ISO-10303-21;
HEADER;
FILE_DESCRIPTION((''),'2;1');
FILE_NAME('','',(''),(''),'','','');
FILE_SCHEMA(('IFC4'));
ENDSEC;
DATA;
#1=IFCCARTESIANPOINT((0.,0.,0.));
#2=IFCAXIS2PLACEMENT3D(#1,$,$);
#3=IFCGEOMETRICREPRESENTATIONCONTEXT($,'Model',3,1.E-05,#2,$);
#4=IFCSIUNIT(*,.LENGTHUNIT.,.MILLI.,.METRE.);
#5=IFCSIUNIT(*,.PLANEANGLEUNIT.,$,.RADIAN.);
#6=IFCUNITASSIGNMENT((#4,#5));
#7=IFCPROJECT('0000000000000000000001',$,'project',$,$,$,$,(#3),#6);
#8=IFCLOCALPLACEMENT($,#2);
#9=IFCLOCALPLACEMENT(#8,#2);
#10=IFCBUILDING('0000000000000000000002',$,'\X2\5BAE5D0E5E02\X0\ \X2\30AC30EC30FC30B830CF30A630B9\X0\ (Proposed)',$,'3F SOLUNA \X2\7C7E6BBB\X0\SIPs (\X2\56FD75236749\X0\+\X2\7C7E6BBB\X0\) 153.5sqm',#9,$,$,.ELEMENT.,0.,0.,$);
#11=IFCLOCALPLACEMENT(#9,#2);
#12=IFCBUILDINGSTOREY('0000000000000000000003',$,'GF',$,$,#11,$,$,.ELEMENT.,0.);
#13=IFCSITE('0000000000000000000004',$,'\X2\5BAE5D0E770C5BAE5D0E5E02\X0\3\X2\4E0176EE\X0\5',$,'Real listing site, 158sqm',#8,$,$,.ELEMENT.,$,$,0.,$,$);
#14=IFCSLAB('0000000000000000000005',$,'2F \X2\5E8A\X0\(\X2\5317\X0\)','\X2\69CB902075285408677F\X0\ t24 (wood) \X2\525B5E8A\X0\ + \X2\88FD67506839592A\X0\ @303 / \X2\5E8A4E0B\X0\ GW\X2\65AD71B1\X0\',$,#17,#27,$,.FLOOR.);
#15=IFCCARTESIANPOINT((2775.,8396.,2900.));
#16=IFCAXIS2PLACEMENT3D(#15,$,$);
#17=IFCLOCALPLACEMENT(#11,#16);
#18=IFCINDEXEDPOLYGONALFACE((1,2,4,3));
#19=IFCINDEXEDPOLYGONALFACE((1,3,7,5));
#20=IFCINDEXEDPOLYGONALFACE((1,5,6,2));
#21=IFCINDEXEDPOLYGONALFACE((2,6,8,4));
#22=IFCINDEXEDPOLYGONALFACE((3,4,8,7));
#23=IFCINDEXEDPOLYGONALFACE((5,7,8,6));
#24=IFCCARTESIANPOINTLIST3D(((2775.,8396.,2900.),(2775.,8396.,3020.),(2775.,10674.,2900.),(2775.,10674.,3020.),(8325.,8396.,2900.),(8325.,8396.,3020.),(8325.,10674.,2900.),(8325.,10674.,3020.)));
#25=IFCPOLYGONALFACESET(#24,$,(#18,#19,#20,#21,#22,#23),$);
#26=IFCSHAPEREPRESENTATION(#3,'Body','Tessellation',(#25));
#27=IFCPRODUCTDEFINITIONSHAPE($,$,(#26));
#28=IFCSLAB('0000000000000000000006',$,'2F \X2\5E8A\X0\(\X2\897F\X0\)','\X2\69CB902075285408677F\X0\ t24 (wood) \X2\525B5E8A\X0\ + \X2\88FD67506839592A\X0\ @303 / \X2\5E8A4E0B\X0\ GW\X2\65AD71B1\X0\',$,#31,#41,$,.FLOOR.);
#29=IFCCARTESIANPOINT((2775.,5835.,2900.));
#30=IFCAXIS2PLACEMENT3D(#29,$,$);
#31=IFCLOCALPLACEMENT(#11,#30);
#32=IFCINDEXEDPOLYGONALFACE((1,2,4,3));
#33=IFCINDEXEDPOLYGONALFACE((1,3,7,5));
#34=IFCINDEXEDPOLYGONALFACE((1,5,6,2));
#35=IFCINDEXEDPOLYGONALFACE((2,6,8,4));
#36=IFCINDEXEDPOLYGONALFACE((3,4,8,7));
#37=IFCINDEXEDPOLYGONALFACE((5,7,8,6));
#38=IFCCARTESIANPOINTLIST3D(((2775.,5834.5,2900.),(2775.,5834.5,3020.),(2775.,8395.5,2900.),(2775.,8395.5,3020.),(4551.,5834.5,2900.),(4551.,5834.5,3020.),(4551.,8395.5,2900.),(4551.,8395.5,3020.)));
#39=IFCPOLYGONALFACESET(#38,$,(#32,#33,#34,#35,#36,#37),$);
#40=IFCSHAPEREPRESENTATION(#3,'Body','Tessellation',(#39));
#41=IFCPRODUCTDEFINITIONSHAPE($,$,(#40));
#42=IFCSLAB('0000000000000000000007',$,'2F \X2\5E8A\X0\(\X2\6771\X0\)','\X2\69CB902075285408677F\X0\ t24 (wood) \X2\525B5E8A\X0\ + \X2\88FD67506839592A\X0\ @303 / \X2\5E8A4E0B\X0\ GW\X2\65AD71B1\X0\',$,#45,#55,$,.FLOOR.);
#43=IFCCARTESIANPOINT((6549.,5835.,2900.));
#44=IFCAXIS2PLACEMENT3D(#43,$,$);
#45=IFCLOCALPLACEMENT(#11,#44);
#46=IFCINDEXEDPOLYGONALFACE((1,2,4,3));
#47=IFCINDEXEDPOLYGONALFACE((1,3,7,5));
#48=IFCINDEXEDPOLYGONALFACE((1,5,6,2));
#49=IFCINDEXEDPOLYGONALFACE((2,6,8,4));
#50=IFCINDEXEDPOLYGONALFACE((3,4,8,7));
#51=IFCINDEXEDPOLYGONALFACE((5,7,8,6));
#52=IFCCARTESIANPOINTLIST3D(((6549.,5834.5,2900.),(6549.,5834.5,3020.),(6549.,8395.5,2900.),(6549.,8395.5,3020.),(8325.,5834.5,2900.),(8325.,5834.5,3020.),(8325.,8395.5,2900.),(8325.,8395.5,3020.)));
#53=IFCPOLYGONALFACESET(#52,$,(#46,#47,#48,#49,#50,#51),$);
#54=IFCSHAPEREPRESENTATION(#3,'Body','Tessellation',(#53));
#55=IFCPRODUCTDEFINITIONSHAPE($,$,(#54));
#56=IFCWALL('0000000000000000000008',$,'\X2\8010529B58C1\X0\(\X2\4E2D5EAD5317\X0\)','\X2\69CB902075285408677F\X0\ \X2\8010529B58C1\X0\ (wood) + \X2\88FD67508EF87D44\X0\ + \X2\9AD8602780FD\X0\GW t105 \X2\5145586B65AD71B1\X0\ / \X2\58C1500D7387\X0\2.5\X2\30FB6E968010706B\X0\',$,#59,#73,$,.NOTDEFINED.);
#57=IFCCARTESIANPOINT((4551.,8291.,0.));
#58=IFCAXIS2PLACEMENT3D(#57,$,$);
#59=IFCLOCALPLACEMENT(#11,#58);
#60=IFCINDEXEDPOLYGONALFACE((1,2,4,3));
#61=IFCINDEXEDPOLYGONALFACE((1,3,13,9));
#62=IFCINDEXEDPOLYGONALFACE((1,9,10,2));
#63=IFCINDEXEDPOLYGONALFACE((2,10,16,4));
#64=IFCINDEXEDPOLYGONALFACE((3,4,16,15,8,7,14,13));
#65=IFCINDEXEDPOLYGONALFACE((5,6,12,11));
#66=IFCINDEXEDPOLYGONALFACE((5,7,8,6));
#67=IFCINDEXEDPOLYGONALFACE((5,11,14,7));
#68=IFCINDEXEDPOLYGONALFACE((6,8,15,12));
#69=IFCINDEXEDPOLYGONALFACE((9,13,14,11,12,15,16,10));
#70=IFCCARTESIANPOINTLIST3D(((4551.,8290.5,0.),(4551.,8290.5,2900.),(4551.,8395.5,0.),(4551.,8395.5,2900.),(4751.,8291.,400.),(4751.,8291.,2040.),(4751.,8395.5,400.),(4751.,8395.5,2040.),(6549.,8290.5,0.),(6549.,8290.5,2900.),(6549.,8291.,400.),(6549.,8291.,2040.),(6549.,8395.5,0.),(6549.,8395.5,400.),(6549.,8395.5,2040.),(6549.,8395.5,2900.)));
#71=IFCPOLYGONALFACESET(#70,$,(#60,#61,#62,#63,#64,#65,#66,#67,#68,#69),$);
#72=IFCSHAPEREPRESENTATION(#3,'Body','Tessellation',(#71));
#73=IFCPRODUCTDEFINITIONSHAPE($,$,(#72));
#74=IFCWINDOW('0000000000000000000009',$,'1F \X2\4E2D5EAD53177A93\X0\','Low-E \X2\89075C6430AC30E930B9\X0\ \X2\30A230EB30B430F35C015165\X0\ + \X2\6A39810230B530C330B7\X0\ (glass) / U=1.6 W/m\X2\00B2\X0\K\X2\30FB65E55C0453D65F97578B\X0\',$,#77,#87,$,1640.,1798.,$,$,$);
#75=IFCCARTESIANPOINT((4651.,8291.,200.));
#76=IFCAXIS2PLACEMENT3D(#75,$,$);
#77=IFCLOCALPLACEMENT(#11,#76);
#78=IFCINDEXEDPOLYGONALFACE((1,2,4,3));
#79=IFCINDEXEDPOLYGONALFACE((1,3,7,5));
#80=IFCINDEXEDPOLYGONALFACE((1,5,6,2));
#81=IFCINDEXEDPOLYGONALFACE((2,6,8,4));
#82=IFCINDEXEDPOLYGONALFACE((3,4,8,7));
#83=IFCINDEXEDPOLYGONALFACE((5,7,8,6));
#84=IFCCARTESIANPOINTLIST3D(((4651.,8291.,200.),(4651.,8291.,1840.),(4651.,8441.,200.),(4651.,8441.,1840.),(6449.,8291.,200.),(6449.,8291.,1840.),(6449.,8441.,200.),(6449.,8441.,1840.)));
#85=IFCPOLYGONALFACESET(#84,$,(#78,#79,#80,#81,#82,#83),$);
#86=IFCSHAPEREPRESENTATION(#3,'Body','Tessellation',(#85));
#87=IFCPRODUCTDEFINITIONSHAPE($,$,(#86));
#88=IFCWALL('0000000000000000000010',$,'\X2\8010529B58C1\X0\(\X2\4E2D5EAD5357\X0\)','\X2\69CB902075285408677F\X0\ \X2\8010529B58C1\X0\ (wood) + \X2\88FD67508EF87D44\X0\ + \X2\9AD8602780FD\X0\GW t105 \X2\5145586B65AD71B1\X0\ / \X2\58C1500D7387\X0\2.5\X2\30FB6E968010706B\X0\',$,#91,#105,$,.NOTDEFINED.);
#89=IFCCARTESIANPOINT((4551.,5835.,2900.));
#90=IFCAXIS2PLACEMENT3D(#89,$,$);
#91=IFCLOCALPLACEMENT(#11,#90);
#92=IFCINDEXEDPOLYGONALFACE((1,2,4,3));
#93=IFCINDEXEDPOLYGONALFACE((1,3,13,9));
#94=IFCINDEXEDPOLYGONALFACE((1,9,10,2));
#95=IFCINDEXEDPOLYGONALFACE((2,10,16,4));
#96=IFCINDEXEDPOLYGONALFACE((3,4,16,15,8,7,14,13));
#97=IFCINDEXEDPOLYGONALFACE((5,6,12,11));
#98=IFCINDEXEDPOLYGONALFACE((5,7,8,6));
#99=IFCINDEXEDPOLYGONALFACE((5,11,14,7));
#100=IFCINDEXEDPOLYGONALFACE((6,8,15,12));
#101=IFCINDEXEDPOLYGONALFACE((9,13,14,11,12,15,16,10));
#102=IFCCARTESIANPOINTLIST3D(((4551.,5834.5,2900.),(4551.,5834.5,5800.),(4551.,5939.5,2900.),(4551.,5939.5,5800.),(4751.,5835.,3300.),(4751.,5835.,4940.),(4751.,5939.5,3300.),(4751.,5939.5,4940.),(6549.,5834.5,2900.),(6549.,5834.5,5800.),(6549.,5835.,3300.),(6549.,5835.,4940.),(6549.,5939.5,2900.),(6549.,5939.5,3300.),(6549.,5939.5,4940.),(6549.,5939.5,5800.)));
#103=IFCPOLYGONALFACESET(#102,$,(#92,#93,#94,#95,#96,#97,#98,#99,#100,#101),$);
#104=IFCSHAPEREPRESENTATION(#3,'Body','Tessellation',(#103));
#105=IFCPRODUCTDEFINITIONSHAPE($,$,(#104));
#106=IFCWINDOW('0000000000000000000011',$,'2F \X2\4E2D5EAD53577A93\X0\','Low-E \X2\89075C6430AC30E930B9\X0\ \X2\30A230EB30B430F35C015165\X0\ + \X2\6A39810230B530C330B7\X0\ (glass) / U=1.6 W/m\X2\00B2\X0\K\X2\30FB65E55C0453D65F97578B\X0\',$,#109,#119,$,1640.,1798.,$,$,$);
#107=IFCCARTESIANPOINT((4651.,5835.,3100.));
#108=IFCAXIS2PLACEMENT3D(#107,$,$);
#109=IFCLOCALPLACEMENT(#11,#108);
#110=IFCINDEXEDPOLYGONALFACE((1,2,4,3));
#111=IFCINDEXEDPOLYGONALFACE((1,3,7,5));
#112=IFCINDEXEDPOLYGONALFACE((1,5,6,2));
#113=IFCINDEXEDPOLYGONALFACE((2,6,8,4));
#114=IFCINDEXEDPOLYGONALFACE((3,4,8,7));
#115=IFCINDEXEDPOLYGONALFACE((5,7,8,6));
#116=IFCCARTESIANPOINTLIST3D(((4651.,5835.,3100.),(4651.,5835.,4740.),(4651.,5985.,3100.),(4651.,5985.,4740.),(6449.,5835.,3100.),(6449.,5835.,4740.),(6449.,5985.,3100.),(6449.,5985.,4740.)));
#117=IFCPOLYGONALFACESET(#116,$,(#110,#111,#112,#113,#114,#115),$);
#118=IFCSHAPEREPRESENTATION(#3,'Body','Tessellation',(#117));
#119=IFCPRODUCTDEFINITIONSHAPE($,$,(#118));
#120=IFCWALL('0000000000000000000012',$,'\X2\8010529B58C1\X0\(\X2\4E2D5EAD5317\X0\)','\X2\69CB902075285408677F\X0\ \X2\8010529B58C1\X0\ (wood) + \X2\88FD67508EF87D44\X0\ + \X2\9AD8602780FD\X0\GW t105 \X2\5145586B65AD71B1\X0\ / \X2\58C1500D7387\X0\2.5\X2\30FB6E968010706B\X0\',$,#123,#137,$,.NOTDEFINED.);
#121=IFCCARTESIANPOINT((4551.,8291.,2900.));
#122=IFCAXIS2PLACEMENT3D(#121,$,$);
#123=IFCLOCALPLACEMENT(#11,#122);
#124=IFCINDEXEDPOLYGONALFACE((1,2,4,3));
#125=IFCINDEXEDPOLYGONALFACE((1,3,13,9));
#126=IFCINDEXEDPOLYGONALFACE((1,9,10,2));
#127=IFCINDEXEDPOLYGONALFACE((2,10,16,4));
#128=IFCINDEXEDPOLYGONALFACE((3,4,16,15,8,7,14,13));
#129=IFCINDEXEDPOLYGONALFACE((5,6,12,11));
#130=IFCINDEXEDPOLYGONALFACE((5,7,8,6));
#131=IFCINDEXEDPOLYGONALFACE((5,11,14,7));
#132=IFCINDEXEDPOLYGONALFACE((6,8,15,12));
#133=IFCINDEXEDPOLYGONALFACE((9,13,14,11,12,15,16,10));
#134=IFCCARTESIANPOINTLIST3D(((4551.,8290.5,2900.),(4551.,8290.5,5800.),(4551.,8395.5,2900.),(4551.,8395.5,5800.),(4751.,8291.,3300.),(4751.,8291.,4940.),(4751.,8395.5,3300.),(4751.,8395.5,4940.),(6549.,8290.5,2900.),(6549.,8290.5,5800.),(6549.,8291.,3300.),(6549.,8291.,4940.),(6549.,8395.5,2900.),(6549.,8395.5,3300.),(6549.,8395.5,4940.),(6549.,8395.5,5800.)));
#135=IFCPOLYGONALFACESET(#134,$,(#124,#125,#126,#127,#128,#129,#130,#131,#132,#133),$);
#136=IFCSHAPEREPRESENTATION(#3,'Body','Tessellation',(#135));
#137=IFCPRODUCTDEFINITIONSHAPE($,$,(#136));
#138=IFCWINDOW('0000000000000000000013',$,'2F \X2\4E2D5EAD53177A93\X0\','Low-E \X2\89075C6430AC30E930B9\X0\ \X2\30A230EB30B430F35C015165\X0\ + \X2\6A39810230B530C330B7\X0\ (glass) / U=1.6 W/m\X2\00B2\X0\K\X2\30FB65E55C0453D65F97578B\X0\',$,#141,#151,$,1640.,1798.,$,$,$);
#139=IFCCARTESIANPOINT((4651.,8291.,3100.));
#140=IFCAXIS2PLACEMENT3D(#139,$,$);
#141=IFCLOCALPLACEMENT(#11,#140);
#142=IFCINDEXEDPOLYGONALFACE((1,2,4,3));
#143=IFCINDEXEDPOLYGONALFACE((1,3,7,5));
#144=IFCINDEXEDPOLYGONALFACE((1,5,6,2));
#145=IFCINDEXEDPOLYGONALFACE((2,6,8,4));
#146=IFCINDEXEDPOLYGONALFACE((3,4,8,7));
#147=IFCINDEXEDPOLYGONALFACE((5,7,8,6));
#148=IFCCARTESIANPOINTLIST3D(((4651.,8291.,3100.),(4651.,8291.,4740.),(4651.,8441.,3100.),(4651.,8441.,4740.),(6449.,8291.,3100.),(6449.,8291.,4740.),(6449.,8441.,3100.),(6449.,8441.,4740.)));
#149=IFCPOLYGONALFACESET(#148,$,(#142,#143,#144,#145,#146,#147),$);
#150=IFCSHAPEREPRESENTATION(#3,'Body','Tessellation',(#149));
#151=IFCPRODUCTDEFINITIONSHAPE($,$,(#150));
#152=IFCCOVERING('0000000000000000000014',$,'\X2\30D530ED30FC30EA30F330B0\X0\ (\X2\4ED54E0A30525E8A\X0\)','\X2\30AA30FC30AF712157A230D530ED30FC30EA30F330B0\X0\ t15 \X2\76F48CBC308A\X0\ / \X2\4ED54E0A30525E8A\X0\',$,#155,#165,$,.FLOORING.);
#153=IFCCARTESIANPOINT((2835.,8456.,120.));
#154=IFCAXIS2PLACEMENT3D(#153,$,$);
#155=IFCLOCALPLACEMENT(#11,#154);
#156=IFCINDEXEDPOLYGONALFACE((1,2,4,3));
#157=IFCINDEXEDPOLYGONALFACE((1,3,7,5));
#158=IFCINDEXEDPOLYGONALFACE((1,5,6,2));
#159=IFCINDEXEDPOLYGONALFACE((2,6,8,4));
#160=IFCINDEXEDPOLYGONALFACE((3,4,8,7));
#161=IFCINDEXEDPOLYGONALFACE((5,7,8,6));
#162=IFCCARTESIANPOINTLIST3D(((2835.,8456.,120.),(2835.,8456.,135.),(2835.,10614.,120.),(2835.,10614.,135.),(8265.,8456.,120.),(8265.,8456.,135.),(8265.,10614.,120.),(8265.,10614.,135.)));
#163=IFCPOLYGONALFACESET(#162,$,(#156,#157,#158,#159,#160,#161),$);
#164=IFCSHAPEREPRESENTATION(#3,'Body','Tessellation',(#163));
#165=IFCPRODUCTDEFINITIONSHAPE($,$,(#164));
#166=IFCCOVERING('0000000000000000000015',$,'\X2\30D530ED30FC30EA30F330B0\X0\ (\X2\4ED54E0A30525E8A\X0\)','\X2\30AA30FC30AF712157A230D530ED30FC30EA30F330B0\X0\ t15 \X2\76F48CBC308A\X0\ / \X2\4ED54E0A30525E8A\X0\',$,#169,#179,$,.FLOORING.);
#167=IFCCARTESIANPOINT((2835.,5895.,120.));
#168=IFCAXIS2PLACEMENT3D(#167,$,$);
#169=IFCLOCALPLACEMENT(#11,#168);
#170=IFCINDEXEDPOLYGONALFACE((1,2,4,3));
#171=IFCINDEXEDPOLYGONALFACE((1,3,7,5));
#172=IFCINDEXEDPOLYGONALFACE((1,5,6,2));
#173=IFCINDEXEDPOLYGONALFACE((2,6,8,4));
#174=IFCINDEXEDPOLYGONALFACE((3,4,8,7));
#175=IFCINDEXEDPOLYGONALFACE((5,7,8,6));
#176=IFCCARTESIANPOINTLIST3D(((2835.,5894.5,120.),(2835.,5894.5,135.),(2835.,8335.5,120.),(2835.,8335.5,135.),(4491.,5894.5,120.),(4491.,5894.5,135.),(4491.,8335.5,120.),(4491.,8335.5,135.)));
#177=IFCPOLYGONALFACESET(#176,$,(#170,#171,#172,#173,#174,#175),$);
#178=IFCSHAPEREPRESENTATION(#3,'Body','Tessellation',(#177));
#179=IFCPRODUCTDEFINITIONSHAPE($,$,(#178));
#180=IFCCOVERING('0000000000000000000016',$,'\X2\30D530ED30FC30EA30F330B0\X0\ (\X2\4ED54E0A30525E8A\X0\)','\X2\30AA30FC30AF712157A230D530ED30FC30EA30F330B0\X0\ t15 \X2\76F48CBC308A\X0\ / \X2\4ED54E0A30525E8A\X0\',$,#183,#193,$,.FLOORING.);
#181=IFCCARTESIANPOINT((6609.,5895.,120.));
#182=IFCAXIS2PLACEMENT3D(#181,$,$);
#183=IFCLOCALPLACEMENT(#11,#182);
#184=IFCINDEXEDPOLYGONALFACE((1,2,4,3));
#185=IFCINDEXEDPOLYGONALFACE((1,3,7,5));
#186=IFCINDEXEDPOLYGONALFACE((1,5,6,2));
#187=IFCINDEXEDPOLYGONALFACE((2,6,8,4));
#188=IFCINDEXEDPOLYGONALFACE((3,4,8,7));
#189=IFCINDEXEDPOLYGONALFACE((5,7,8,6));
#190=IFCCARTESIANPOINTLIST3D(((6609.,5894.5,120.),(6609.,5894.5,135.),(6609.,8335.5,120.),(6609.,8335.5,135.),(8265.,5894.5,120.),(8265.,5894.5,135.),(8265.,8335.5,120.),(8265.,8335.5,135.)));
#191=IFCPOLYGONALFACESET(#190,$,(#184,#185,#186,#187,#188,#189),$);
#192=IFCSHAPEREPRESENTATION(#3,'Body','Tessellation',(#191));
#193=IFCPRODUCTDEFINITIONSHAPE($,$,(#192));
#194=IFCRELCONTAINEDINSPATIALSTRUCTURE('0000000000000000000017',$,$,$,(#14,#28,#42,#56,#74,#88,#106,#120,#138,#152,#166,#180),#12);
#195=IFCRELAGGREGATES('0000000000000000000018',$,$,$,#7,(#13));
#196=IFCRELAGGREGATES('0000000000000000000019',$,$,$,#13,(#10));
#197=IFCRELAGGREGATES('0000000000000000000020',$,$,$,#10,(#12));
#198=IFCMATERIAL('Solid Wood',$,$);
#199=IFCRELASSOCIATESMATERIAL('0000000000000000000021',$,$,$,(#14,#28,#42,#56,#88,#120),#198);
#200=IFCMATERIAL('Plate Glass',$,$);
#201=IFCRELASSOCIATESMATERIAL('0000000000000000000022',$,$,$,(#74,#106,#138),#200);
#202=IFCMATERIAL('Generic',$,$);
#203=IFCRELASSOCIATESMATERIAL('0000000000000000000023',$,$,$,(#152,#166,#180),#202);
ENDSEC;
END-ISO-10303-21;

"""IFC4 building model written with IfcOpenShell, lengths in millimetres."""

from ifc_helpers import new_model, si_unit, frame, frame_2d, origin, place, context, project, spatial, rectangle, extrude, material, element, fill, save


model = new_model("IFC4")

# Units and contexts
model_context = context("Model", 3, precision=1e-05, world=origin())
ifc_project = project(units=[si_unit("LENGTHUNIT", "METRE", prefix="MILLI"), si_unit("PLANEANGLEUNIT", "RADIAN")], contexts=[model_context])

# Site, building, storey
site_placement = place(None, origin())
site = spatial("IfcSite", under=ifc_project, at=site_placement, Name="宮崎県宮崎市3丁目5", ObjectType="Real listing site, 158sqm", CompositionType="ELEMENT", RefElevation=0.0)
building_placement = place(site_placement, origin())
building = spatial("IfcBuilding", under=site, at=building_placement, Name="宮崎市 ガレージハウス (Proposed)", ObjectType="3F SOLUNA 籾殻SIPs (国産杉+籾殻) 153.5sqm", CompositionType="ELEMENT", ElevationOfRefHeight=0.0, ElevationOfTerrain=0.0)
storey_placement = place(building_placement, origin())
storey = spatial("IfcBuildingStorey", under=building, at=storey_placement, Name="GF", CompositionType="ELEMENT", Elevation=0.0)

# Slabs
ifc_material_1 = material(Name="Solid Wood")
slab_1_placement = place(storey_placement, frame((2775.0, 8396.0, 2900.0)))
element("IfcSlab", 1, at=slab_1_placement, inside=storey, material=ifc_material_1, Name="2F 床(北)", Description="構造用合板 t24 (wood) 剛床 + 製材根太 @303 / 床下 GW断熱", PredefinedType="FLOOR", context=model_context, shape_type="SweptSolid", body=[
    extrude(rectangle(XDim=5550.0, YDim=2278.0, at=frame_2d((2775.0, 1139.0))), frame((2775.0, 8396.0, 2900.0)), (0.0, 0.0, 1.0), 120.0),
])
slab_2_placement = place(storey_placement, frame((2775.0, 5835.0, 2900.0)))
element("IfcSlab", 2, at=slab_2_placement, inside=storey, material=ifc_material_1, Name="2F 床(西)", Description="構造用合板 t24 (wood) 剛床 + 製材根太 @303 / 床下 GW断熱", PredefinedType="FLOOR", context=model_context, shape_type="SweptSolid", body=[
    extrude(rectangle(XDim=1776.0, YDim=2561.0, at=frame_2d((888.0, 1280.0))), frame((2775.0, 5835.0, 2900.0)), (0.0, 0.0, 1.0), 120.0),
])
slab_3_placement = place(storey_placement, frame((6549.0, 5835.0, 2900.0)))
element("IfcSlab", 3, at=slab_3_placement, inside=storey, material=ifc_material_1, Name="2F 床(東)", Description="構造用合板 t24 (wood) 剛床 + 製材根太 @303 / 床下 GW断熱", PredefinedType="FLOOR", context=model_context, shape_type="SweptSolid", body=[
    extrude(rectangle(XDim=1776.0, YDim=2561.0, at=frame_2d((888.0, 1280.0))), frame((6549.0, 5835.0, 2900.0)), (0.0, 0.0, 1.0), 120.0),
])

# Wall, opening, window
wall_1_placement = place(storey_placement, frame((4551.0, 8291.0, 0.0)))
wall_1 = element("IfcWall", 4, at=wall_1_placement, inside=storey, material=ifc_material_1, Name="耐力壁(中庭北)", Description="構造用合板 耐力壁 (wood) + 製材軸組 + 高性能GW t105 充填断熱 / 壁倍率2.5・準耐火", PredefinedType="NOTDEFINED", context=model_context, shape_type="SweptSolid", body=[
    extrude(rectangle(XDim=1998.0, YDim=105.0, at=frame_2d((999.0, 52.0))), frame((4551.0, 8291.0, 0.0)), (0.0, 0.0, 1.0), 2900.0),
])
opening_1_placement = place(storey_placement, frame((4651.0, 8291.0, 200.0)))
opening_1 = element("IfcOpeningElement", 5, at=opening_1_placement, cuts=wall_1, PredefinedType="NOTDEFINED", context=model_context, shape_type="SweptSolid", body=[
    extrude(rectangle(XDim=1798.0, YDim=150.0, at=frame_2d((899.0, 75.0))), frame((4651.0, 8291.0, 200.0)), (0.0, 0.0, 1.0), 1640.0),
])
ifc_material_2 = material(Name="Plate Glass")
window_1_placement = place(storey_placement, frame((4651.0, 8291.0, 200.0)))
window_1 = element("IfcWindow", 6, at=window_1_placement, inside=storey, material=ifc_material_2, Name="1F 中庭北窓", Description="Low-E 複層ガラス アルゴン封入 + 樹脂サッシ (glass) / U=1.6 W/m²K・日射取得型", OverallHeight=1640.0, OverallWidth=1798.0, context=model_context, shape_type="SweptSolid", body=[
    extrude(rectangle(XDim=1798.0, YDim=150.0, at=frame_2d((899.0, 75.0))), frame((4651.0, 8291.0, 200.0)), (0.0, 0.0, 1.0), 1640.0),
])
fill(opening_1, window_1)

# Walls, openings, windows
wall_2_placement = place(storey_placement, frame((4551.0, 5835.0, 2900.0)))
wall_2 = element("IfcWall", 7, at=wall_2_placement, inside=storey, material=ifc_material_1, Name="耐力壁(中庭南)", Description="構造用合板 耐力壁 (wood) + 製材軸組 + 高性能GW t105 充填断熱 / 壁倍率2.5・準耐火", PredefinedType="NOTDEFINED", context=model_context, shape_type="SweptSolid", body=[
    extrude(rectangle(XDim=1998.0, YDim=105.0, at=frame_2d((999.0, 52.0))), frame((4551.0, 5835.0, 2900.0)), (0.0, 0.0, 1.0), 2900.0),
])
opening_2_placement = place(storey_placement, frame((4651.0, 5835.0, 3100.0)))
opening_2 = element("IfcOpeningElement", 8, at=opening_2_placement, cuts=wall_2, PredefinedType="NOTDEFINED", context=model_context, shape_type="SweptSolid", body=[
    extrude(rectangle(XDim=1798.0, YDim=150.0, at=frame_2d((899.0, 75.0))), frame((4651.0, 5835.0, 3100.0)), (0.0, 0.0, 1.0), 1640.0),
])
window_2_placement = place(storey_placement, frame((4651.0, 5835.0, 3100.0)))
window_2 = element("IfcWindow", 9, at=window_2_placement, inside=storey, material=ifc_material_2, Name="2F 中庭南窓", Description="Low-E 複層ガラス アルゴン封入 + 樹脂サッシ (glass) / U=1.6 W/m²K・日射取得型", OverallHeight=1640.0, OverallWidth=1798.0, context=model_context, shape_type="SweptSolid", body=[
    extrude(rectangle(XDim=1798.0, YDim=150.0, at=frame_2d((899.0, 75.0))), frame((4651.0, 5835.0, 3100.0)), (0.0, 0.0, 1.0), 1640.0),
])
fill(opening_2, window_2)
wall_3_placement = place(storey_placement, frame((4551.0, 8291.0, 2900.0)))
wall_3 = element("IfcWall", 10, at=wall_3_placement, inside=storey, material=ifc_material_1, Name="耐力壁(中庭北)", Description="構造用合板 耐力壁 (wood) + 製材軸組 + 高性能GW t105 充填断熱 / 壁倍率2.5・準耐火", PredefinedType="NOTDEFINED", context=model_context, shape_type="SweptSolid", body=[
    extrude(rectangle(XDim=1998.0, YDim=105.0, at=frame_2d((999.0, 52.0))), frame((4551.0, 8291.0, 2900.0)), (0.0, 0.0, 1.0), 2900.0),
])
opening_3_placement = place(storey_placement, frame((4651.0, 8291.0, 3100.0)))
opening_3 = element("IfcOpeningElement", 11, at=opening_3_placement, cuts=wall_3, PredefinedType="NOTDEFINED", context=model_context, shape_type="SweptSolid", body=[
    extrude(rectangle(XDim=1798.0, YDim=150.0, at=frame_2d((899.0, 75.0))), frame((4651.0, 8291.0, 3100.0)), (0.0, 0.0, 1.0), 1640.0),
])
window_3_placement = place(storey_placement, frame((4651.0, 8291.0, 3100.0)))
window_3 = element("IfcWindow", 12, at=window_3_placement, inside=storey, material=ifc_material_2, Name="2F 中庭北窓", Description="Low-E 複層ガラス アルゴン封入 + 樹脂サッシ (glass) / U=1.6 W/m²K・日射取得型", OverallHeight=1640.0, OverallWidth=1798.0, context=model_context, shape_type="SweptSolid", body=[
    extrude(rectangle(XDim=1798.0, YDim=150.0, at=frame_2d((899.0, 75.0))), frame((4651.0, 8291.0, 3100.0)), (0.0, 0.0, 1.0), 1640.0),
])
fill(opening_3, window_3)

# Coverings
ifc_material_3 = material(Name="Generic")
covering_1_placement = place(storey_placement, frame((2835.0, 8456.0, 120.0)))
element("IfcCovering", 13, at=covering_1_placement, inside=storey, material=ifc_material_3, Name="フローリング (仕上げ床)", Description="オーク無垢フローリング t15 直貼り / 仕上げ床", PredefinedType="FLOORING", context=model_context, shape_type="SweptSolid", body=[
    extrude(rectangle(XDim=5430.0, YDim=2158.0, at=frame_2d((2715.0, 1079.0))), frame((2835.0, 8456.0, 120.0)), (0.0, 0.0, 1.0), 15.0),
])
covering_2_placement = place(storey_placement, frame((2835.0, 5895.0, 120.0)))
element("IfcCovering", 14, at=covering_2_placement, inside=storey, material=ifc_material_3, Name="フローリング (仕上げ床)", Description="オーク無垢フローリング t15 直貼り / 仕上げ床", PredefinedType="FLOORING", context=model_context, shape_type="SweptSolid", body=[
    extrude(rectangle(XDim=1656.0, YDim=2441.0, at=frame_2d((828.0, 1220.0))), frame((2835.0, 5895.0, 120.0)), (0.0, 0.0, 1.0), 15.0),
])
covering_3_placement = place(storey_placement, frame((6609.0, 5895.0, 120.0)))
element("IfcCovering", 15, at=covering_3_placement, inside=storey, material=ifc_material_3, Name="フローリング (仕上げ床)", Description="オーク無垢フローリング t15 直貼り / 仕上げ床", PredefinedType="FLOORING", context=model_context, shape_type="SweptSolid", body=[
    extrude(rectangle(XDim=1656.0, YDim=2441.0, at=frame_2d((828.0, 1220.0))), frame((6609.0, 5895.0, 120.0)), (0.0, 0.0, 1.0), 15.0),
])

save(model, "model.ifc")
